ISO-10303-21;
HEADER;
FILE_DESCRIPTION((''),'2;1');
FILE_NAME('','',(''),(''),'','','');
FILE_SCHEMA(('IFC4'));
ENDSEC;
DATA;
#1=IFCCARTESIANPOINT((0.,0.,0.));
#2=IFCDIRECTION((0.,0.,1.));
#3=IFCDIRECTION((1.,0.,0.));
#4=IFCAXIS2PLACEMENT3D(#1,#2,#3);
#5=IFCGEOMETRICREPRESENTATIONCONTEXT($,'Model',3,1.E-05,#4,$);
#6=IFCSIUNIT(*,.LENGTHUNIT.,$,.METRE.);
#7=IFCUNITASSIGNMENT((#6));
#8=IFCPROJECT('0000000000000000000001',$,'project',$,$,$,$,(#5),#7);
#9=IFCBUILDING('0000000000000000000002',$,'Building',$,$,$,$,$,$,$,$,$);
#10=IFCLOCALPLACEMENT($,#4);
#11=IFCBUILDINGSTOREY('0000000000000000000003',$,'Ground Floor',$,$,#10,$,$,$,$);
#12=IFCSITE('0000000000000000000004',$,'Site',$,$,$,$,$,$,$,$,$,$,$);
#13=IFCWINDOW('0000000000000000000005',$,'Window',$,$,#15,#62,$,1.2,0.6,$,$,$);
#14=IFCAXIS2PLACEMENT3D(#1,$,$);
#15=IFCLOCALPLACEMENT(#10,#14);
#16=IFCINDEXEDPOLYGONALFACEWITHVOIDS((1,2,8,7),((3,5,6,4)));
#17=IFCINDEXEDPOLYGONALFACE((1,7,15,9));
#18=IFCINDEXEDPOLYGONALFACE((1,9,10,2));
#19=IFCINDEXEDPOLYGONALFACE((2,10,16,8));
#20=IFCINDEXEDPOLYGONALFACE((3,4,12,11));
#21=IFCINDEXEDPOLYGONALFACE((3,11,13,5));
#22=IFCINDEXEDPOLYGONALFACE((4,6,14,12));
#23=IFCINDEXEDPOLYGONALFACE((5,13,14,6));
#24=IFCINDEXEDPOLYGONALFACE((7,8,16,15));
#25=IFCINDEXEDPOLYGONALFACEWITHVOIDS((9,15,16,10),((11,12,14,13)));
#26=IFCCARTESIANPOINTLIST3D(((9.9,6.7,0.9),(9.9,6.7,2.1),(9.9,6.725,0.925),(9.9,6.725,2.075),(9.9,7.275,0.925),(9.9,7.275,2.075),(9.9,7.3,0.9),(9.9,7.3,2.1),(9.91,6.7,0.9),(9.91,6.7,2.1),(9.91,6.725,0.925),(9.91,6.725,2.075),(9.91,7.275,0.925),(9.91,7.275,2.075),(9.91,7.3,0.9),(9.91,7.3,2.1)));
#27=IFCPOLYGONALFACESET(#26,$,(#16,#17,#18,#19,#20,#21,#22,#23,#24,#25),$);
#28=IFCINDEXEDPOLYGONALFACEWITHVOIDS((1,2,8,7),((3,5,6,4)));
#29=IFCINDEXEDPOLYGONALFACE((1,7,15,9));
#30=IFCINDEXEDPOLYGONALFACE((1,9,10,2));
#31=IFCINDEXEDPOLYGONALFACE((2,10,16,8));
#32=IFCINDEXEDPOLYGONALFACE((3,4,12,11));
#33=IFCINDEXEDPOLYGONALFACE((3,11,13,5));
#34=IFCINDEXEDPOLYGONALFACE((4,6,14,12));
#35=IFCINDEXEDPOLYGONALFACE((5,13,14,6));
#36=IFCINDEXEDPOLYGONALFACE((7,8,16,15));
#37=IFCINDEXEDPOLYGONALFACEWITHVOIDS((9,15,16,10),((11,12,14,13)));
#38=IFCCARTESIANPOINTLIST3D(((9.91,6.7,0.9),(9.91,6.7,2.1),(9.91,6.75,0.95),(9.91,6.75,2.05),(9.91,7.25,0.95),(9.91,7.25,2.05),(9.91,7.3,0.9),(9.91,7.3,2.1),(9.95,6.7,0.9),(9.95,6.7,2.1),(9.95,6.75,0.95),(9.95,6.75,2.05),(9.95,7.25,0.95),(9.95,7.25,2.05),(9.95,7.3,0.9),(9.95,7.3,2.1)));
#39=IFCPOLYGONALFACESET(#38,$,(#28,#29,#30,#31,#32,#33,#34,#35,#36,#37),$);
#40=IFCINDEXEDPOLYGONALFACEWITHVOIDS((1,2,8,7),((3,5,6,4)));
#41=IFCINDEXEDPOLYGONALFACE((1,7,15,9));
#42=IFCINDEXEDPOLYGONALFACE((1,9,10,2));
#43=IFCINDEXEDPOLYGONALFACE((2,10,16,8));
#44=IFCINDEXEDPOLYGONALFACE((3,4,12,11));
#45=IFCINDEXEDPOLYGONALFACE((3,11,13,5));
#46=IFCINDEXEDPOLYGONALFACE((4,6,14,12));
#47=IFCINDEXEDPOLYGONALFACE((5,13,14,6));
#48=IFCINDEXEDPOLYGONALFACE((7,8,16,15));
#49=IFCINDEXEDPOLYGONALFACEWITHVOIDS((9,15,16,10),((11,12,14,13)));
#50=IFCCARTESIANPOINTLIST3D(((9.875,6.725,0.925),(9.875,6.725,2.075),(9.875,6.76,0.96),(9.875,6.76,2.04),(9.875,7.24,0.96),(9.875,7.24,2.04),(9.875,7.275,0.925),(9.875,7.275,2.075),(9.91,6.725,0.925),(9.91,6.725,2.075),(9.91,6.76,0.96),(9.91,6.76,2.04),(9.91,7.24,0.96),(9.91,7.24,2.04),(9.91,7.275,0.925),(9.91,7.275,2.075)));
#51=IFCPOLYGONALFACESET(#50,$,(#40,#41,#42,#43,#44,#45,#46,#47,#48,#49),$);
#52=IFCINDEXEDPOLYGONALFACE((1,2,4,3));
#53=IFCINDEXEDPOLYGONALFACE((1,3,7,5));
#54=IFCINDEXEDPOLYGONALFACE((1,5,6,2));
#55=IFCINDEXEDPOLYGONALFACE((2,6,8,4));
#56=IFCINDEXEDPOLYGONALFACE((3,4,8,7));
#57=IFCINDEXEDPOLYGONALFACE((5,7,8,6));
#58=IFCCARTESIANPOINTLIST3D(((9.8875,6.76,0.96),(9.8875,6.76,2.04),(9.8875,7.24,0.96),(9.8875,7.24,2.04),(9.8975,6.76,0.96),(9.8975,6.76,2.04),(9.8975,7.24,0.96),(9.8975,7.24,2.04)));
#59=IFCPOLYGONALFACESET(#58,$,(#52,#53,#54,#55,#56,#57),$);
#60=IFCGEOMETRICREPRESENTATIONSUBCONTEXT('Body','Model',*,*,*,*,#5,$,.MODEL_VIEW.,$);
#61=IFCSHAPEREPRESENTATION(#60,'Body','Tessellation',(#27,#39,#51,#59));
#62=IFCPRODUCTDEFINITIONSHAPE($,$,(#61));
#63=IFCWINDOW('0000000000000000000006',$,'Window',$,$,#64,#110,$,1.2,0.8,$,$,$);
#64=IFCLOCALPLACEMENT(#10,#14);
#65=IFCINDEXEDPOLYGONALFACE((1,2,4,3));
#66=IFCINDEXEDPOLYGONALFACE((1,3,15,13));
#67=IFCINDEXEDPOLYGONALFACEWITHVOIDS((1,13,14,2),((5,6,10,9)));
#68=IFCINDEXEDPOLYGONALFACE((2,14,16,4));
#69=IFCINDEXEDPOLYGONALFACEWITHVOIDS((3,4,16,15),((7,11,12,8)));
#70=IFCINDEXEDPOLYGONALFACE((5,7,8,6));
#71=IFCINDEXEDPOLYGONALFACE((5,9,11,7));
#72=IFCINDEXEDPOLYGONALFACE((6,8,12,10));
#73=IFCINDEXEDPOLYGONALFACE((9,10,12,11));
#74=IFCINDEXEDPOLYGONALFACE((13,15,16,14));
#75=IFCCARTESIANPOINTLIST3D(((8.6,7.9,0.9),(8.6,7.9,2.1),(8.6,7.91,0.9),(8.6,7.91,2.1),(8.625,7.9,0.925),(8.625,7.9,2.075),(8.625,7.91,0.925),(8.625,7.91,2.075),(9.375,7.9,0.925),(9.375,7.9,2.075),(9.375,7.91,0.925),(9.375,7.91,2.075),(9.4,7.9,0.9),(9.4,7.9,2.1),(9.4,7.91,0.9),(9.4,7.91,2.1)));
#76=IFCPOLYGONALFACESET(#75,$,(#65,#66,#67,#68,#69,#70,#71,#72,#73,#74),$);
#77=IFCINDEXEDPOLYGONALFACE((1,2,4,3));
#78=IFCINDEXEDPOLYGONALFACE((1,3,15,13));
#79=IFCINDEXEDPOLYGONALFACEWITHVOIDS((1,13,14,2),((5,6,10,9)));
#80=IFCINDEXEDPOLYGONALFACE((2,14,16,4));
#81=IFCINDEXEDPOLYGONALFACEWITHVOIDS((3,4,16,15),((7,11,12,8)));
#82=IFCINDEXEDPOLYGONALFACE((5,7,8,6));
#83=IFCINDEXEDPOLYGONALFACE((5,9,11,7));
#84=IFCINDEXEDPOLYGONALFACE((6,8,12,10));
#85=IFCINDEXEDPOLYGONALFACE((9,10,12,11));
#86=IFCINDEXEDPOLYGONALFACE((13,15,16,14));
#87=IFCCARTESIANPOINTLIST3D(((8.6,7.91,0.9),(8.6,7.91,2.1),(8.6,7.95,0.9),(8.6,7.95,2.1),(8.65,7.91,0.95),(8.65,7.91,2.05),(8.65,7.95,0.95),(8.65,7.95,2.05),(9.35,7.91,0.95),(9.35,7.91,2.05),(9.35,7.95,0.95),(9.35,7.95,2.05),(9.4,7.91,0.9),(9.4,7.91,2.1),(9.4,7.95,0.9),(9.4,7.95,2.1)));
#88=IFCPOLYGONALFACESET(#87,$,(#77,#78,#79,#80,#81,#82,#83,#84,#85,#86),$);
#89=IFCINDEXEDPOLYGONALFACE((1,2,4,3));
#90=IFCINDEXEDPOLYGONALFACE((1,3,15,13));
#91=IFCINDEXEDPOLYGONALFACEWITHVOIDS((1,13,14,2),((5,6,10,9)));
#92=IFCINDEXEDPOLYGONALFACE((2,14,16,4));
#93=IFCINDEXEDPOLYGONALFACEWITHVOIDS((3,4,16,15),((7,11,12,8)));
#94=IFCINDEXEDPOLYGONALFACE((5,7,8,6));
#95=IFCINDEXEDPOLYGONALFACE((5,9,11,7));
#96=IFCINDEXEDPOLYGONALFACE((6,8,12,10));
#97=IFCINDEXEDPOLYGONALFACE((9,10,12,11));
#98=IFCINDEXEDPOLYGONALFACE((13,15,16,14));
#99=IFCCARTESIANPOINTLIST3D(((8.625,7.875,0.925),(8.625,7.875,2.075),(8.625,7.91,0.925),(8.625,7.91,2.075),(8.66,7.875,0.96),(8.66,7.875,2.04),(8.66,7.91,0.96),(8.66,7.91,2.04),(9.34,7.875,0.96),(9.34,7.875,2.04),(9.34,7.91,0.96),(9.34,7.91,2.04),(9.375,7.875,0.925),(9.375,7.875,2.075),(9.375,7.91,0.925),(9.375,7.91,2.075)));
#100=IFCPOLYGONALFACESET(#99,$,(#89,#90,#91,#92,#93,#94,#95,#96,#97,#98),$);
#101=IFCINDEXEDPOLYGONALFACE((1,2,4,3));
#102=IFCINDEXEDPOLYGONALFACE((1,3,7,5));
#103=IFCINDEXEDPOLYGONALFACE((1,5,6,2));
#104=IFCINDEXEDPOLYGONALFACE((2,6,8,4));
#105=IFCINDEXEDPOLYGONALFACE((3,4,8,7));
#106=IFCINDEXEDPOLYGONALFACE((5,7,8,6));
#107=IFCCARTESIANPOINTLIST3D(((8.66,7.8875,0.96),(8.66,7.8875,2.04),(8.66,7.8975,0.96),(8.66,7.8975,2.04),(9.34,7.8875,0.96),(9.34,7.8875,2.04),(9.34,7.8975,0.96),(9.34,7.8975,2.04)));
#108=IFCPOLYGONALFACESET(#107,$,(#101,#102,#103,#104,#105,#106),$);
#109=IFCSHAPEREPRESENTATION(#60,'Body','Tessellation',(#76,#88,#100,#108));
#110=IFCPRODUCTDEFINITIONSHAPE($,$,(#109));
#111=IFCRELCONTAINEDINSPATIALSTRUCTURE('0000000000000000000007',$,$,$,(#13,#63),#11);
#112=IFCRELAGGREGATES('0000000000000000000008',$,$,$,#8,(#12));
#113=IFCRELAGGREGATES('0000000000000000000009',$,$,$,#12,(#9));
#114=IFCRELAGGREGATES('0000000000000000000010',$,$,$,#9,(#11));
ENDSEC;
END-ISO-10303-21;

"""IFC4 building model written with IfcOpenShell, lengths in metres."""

from ifc_helpers import new_model, si_unit, frame, origin_with_axes, place, context, subcontext, project, spatial, line, indexed_curve, outline, extrude, element, save


model = new_model("IFC4")

# Units and contexts
model_context = context("Model", 3, precision=1e-05, world=origin_with_axes())
body_context = subcontext(model_context, "Body", "Model", "MODEL_VIEW")
ifc_project = project(units=[si_unit("LENGTHUNIT", "METRE")], contexts=[model_context])

# Site, building, storey
site = spatial("IfcSite", under=ifc_project, Name="Site")
building = spatial("IfcBuilding", under=site, Name="Building")
storey_placement = place(None, origin_with_axes())
storey = spatial("IfcBuildingStorey", under=building, at=storey_placement, Name="Ground Floor")

# Windows
window_1_placement = place(storey_placement, frame((10.0, 6.7, 0.9), z_axis=(0.0, 0.0, 1.0), x_axis=(0.0, 1.0, 0.0)))
element("IfcWindow", 1, at=window_1_placement, inside=storey, Name="Window", OverallHeight=1.2, OverallWidth=0.6, context=body_context, shape_type="SweptSolid", body=[
    extrude(outline(indexed_curve([(0.0, 0.0), (0.6, 0.0), (0.6, 1.2), (0.0, 1.2)], segments=[line(1, 2, 3, 4, 1)]), holes=[indexed_curve([(0.025, 0.025), (0.575, 0.025), (0.575, 1.175), (0.025, 1.175)], segments=[line(1, 2, 3, 4, 1)])]), frame((0.0, 0.09, 0.0), z_axis=(0.0, -1.0, 0.0), x_axis=(1.0, 0.0, 0.0)), (0.0, 0.0, -1.0), 0.01),
    extrude(outline(indexed_curve([(0.0, 0.0), (0.6, 0.0), (0.6, 1.2), (0.0, 1.2)], segments=[line(1, 2, 3, 4, 1)]), holes=[indexed_curve([(0.05, 0.05), (0.55, 0.05), (0.55, 1.15), (0.05, 1.15)], segments=[line(1, 2, 3, 4, 1)])]), frame((0.0, 0.05, 0.0), z_axis=(0.0, -1.0, 0.0), x_axis=(1.0, 0.0, 0.0)), (0.0, 0.0, -1.0), 0.04),
    extrude(outline(indexed_curve([(0.0, 0.0), (0.55, 0.0), (0.55, 1.15), (0.0, 1.15)], segments=[line(1, 2, 3, 4, 1)]), holes=[indexed_curve([(0.035, 0.035), (0.515, 0.035), (0.515, 1.115), (0.035, 1.115)], segments=[line(1, 2, 3, 4, 1)])]), frame((0.025, 0.09, 0.025), z_axis=(0.0, -1.0, 0.0), x_axis=(1.0, 0.0, 0.0)), (0.0, 0.0, -1.0), 0.035),
    extrude(outline(indexed_curve([(0.035, 0.035), (0.515, 0.035), (0.515, 1.115), (0.035, 1.115)], segments=[line(1, 2, 3, 4, 1)])), frame((0.025, 0.1025, 0.025), z_axis=(0.0, -1.0, 0.0), x_axis=(1.0, 0.0, 0.0)), (0.0, 0.0, -1.0), 0.01),
])
window_2_placement = place(storey_placement, frame((9.4, 8.0, 0.9), z_axis=(0.0, 0.0, 1.0), x_axis=(-1.0, 0.0, 0.0)))
element("IfcWindow", 2, at=window_2_placement, inside=storey, Name="Window", OverallHeight=1.2, OverallWidth=0.8, context=body_context, shape_type="SweptSolid", body=[
    extrude(outline(indexed_curve([(0.0, 0.0), (0.8, 0.0), (0.8, 1.2), (0.0, 1.2)], segments=[line(1, 2, 3, 4, 1)]), holes=[indexed_curve([(0.025, 0.025), (0.775, 0.025), (0.775, 1.175), (0.025, 1.175)], segments=[line(1, 2, 3, 4, 1)])]), frame((0.0, 0.09, 0.0), z_axis=(0.0, -1.0, 0.0), x_axis=(1.0, 0.0, 0.0)), (0.0, 0.0, -1.0), 0.01),
    extrude(outline(indexed_curve([(0.0, 0.0), (0.8, 0.0), (0.8, 1.2), (0.0, 1.2)], segments=[line(1, 2, 3, 4, 1)]), holes=[indexed_curve([(0.05, 0.05), (0.75, 0.05), (0.75, 1.15), (0.05, 1.15)], segments=[line(1, 2, 3, 4, 1)])]), frame((0.0, 0.05, 0.0), z_axis=(0.0, -1.0, 0.0), x_axis=(1.0, 0.0, 0.0)), (0.0, 0.0, -1.0), 0.04),
    extrude(outline(indexed_curve([(0.0, 0.0), (0.75, 0.0), (0.75, 1.15), (0.0, 1.15)], segments=[line(1, 2, 3, 4, 1)]), holes=[indexed_curve([(0.035, 0.035), (0.715, 0.035), (0.715, 1.115), (0.035, 1.115)], segments=[line(1, 2, 3, 4, 1)])]), frame((0.025, 0.09, 0.025), z_axis=(0.0, -1.0, 0.0), x_axis=(1.0, 0.0, 0.0)), (0.0, 0.0, -1.0), 0.035),
    extrude(outline(indexed_curve([(0.035, 0.035), (0.715, 0.035), (0.715, 1.115), (0.035, 1.115)], segments=[line(1, 2, 3, 4, 1)])), frame((0.025, 0.1025, 0.025), z_axis=(0.0, -1.0, 0.0), x_axis=(1.0, 0.0, 0.0)), (0.0, 0.0, -1.0), 0.01),
])

save(model, "model.ifc")
